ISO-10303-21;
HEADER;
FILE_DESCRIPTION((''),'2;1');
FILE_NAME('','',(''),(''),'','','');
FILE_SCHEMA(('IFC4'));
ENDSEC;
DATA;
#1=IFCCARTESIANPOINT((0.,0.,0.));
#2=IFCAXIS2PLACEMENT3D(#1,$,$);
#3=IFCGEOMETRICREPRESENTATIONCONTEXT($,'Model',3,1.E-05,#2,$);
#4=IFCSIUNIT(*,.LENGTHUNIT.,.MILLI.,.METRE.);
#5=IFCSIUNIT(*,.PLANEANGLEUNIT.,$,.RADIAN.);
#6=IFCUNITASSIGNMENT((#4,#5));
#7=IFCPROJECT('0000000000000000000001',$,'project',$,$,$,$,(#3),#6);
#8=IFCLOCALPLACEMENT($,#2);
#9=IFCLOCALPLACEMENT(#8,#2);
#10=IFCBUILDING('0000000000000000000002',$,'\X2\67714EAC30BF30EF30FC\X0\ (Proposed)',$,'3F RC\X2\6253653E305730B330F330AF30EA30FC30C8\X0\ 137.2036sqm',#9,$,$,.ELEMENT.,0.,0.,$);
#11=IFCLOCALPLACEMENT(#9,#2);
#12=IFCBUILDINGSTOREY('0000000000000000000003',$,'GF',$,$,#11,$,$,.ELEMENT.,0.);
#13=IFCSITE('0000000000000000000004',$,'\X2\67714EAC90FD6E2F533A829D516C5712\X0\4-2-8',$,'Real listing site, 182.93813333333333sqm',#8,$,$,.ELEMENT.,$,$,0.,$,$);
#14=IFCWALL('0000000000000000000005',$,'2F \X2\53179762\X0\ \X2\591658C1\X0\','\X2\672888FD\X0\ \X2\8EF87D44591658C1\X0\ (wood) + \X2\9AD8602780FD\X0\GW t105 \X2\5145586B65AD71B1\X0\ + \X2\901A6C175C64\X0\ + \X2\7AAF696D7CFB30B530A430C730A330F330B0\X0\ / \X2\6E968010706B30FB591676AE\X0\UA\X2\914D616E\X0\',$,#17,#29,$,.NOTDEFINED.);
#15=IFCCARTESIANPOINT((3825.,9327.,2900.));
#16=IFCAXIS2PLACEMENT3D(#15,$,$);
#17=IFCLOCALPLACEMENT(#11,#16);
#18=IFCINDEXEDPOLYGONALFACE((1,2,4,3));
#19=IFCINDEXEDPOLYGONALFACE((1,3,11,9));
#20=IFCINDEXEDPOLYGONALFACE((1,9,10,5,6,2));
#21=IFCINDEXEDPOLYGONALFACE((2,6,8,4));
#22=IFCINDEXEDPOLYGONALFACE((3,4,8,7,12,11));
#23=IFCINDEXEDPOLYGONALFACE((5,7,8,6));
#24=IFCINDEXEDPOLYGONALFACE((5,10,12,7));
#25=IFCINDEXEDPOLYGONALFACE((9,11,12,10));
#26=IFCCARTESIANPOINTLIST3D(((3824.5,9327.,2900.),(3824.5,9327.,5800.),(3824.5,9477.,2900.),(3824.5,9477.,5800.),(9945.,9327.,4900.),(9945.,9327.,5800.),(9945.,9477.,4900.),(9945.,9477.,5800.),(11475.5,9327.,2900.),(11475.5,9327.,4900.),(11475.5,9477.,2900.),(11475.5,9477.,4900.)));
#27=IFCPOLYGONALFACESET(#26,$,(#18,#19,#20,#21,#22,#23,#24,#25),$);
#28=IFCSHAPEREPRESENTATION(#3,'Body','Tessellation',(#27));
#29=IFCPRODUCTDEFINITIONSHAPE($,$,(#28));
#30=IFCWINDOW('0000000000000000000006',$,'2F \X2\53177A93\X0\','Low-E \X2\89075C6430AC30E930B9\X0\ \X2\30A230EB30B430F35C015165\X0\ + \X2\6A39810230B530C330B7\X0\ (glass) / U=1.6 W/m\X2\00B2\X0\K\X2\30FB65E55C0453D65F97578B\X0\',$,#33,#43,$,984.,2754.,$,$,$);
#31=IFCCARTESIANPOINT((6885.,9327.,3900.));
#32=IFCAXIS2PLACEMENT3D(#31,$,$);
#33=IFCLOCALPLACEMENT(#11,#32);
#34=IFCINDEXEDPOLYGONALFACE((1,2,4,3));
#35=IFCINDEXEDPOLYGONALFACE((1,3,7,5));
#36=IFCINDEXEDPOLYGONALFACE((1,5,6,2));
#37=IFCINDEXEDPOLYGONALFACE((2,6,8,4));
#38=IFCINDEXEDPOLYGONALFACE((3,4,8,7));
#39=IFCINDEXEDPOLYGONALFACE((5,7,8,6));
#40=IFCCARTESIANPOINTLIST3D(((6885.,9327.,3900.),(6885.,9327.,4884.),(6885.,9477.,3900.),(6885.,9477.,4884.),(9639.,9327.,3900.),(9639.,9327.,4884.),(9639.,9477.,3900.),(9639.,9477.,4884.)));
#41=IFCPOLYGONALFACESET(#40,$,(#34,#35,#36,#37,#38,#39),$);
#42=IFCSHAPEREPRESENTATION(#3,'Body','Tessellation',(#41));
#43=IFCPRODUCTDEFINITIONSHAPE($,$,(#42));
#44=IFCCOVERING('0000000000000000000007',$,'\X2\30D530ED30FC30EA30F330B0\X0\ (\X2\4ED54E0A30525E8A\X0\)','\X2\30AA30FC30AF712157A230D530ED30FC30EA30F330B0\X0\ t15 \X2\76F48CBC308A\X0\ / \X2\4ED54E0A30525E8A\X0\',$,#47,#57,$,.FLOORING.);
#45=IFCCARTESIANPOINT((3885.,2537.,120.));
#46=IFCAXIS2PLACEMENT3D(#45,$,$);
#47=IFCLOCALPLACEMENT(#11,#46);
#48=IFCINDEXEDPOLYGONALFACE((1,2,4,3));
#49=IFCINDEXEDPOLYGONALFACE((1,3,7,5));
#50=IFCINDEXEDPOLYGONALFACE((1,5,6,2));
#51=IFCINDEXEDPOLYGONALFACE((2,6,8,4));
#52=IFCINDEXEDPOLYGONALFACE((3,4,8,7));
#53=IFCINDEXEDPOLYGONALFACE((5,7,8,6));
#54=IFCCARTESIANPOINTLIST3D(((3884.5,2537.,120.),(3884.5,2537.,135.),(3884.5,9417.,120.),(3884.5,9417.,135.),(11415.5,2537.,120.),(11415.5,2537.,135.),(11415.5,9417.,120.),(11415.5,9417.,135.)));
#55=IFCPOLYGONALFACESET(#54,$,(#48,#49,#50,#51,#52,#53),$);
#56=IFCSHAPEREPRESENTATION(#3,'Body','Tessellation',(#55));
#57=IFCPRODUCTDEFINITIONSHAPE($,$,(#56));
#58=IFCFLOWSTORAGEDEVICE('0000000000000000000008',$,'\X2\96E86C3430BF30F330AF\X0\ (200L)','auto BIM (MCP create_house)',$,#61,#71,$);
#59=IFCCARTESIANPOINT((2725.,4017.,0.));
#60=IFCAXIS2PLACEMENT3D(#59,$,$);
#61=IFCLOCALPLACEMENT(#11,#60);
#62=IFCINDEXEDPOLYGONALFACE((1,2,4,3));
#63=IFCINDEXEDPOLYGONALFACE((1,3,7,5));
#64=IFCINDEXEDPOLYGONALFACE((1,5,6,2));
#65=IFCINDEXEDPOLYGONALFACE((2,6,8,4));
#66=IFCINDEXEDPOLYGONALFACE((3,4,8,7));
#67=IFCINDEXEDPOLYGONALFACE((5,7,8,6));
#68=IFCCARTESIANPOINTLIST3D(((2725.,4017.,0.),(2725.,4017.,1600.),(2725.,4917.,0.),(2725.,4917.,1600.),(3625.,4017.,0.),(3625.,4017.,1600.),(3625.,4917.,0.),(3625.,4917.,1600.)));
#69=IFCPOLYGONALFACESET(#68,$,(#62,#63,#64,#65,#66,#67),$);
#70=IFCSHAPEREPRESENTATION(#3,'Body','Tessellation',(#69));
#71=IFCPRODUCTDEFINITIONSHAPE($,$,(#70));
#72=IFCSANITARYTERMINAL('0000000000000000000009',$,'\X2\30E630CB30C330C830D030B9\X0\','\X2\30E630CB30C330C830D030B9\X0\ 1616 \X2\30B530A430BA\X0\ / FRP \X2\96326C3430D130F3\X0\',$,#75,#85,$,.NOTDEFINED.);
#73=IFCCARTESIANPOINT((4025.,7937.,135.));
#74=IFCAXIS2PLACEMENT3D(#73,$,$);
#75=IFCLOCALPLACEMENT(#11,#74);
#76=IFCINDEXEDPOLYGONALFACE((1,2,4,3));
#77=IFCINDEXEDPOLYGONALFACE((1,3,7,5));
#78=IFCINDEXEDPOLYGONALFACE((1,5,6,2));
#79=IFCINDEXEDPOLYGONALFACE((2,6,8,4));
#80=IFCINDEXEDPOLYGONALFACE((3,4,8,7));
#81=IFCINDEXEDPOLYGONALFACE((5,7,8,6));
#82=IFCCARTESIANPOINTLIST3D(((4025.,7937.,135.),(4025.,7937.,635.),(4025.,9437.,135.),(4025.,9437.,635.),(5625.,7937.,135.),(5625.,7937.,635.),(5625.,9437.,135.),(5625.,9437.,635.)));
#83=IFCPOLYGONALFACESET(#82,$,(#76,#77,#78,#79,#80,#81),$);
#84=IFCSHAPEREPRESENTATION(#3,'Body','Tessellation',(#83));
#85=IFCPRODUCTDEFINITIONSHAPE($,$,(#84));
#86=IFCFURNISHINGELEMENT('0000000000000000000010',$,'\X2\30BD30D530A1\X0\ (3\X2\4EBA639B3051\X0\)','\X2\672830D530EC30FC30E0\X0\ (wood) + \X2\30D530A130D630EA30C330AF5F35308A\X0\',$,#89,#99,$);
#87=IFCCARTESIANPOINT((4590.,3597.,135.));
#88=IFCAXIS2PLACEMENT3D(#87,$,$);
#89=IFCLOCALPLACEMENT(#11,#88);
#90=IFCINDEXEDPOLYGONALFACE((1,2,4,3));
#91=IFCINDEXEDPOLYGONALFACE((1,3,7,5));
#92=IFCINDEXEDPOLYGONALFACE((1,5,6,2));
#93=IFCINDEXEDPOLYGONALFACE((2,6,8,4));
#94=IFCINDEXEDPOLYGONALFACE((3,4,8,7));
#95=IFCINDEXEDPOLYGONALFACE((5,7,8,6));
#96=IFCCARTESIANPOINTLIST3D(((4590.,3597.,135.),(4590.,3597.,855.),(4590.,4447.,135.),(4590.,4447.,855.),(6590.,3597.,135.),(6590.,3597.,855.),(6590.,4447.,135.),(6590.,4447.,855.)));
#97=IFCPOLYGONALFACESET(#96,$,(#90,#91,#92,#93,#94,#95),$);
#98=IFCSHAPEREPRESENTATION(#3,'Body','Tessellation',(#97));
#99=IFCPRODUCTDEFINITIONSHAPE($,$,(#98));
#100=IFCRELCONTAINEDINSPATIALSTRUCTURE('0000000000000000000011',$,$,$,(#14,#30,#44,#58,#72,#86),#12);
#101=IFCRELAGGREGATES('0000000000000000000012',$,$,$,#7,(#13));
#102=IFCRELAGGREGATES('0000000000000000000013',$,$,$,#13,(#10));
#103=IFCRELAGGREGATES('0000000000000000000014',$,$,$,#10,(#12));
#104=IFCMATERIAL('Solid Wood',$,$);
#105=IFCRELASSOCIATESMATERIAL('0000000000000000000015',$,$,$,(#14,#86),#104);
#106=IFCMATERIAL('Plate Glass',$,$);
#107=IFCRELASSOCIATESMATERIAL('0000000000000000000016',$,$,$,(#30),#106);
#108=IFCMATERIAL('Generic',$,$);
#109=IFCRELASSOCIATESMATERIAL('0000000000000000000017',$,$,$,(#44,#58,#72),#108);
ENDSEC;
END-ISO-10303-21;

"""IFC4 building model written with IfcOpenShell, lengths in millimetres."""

from ifc_helpers import new_model, si_unit, frame, frame_2d, origin, place, context, project, spatial, rectangle, extrude, material, element, fill, save


model = new_model("IFC4")

# Units and contexts
model_context = context("Model", 3, precision=1e-05, world=origin())
ifc_project = project(units=[si_unit("LENGTHUNIT", "METRE", prefix="MILLI"), si_unit("PLANEANGLEUNIT", "RADIAN")], contexts=[model_context])

# Site, building, storey
site_placement = place(None, origin())
site = spatial("IfcSite", under=ifc_project, at=site_placement, Name="東京都港区芝公園4-2-8", ObjectType="Real listing site, 182.93813333333333sqm", CompositionType="ELEMENT", RefElevation=0.0)
building_placement = place(site_placement, origin())
building = spatial("IfcBuilding", under=site, at=building_placement, Name="東京タワー (Proposed)", ObjectType="3F RC打放しコンクリート 137.2036sqm", CompositionType="ELEMENT", ElevationOfRefHeight=0.0, ElevationOfTerrain=0.0)
storey_placement = place(building_placement, origin())
storey = spatial("IfcBuildingStorey", under=building, at=storey_placement, Name="GF", CompositionType="ELEMENT", Elevation=0.0)

# Shared definitions
ifc_material_1 = material(Name="Solid Wood")

# Shared definitions
ifc_material_2 = material(Name="Plate Glass")

# Wall, opening, window
wall_1_placement = place(storey_placement, frame((3825.0, 9327.0, 2900.0)))
wall_1 = element("IfcWall", 1, at=wall_1_placement, inside=storey, material=ifc_material_1, Name="2F 北面 外壁", Description="木製 軸組外壁 (wood) + 高性能GW t105 充填断熱 + 通気層 + 窯業系サイディング / 準耐火・外皮UA配慮", PredefinedType="NOTDEFINED", context=model_context, shape_type="SweptSolid", body=[
    extrude(rectangle(XDim=7651.0, YDim=150.0, at=frame_2d((3825.0, 75.0))), frame((3825.0, 9327.0, 2900.0)), (0.0, 0.0, 1.0), 2900.0),
])
opening_1_placement = place(storey_placement, frame((6885.0, 9327.0, 3900.0)))
opening_1 = element("IfcOpeningElement", 2, at=opening_1_placement, cuts=wall_1, PredefinedType="NOTDEFINED", context=model_context, shape_type="SweptSolid", body=[
    extrude(rectangle(XDim=2754.0, YDim=150.0, at=frame_2d((1377.0, 75.0))), frame((6885.0, 9327.0, 3900.0)), (0.0, 0.0, 1.0), 984.0),
])
window_1_placement = place(storey_placement, frame((6885.0, 9327.0, 3900.0)))
window_1 = element("IfcWindow", 3, at=window_1_placement, inside=storey, material=ifc_material_2, Name="2F 北窓", Description="Low-E 複層ガラス アルゴン封入 + 樹脂サッシ (glass) / U=1.6 W/m²K・日射取得型", OverallHeight=984.0, OverallWidth=2754.0, context=model_context, shape_type="SweptSolid", body=[
    extrude(rectangle(XDim=2754.0, YDim=150.0, at=frame_2d((1377.0, 75.0))), frame((6885.0, 9327.0, 3900.0)), (0.0, 0.0, 1.0), 984.0),
])
fill(opening_1, window_1)

# Covering
ifc_material_3 = material(Name="Generic")
covering_placement = place(storey_placement, frame((3885.0, 2537.0, 120.0)))
element("IfcCovering", 4, at=covering_placement, inside=storey, material=ifc_material_3, Name="フローリング (仕上げ床)", Description="オーク無垢フローリング t15 直貼り / 仕上げ床", PredefinedType="FLOORING", context=model_context, shape_type="SweptSolid", body=[
    extrude(rectangle(XDim=7531.0, YDim=6880.0, at=frame_2d((3765.0, 3440.0))), frame((3885.0, 2537.0, 120.0)), (0.0, 0.0, 1.0), 15.0),
])

# Flow storage device
flow_storage_device_placement = place(storey_placement, frame((2725.0, 4017.0, 0.0)))
element("IfcFlowStorageDevice", 5, at=flow_storage_device_placement, inside=storey, material=ifc_material_3, Name="雨水タンク (200L)", Description="auto BIM (MCP create_house)", context=model_context, shape_type="SweptSolid", body=[
    extrude(rectangle(XDim=900.0, YDim=900.0, at=frame_2d((450.0, 450.0))), frame((2725.0, 4017.0, 0.0)), (0.0, 0.0, 1.0), 1600.0),
])

# Sanitary terminal
sanitary_terminal_placement = place(storey_placement, frame((4025.0, 7937.0, 135.0)))
element("IfcSanitaryTerminal", 6, at=sanitary_terminal_placement, inside=storey, material=ifc_material_3, Name="ユニットバス", Description="ユニットバス 1616 サイズ / FRP 防水パン", PredefinedType="NOTDEFINED", context=model_context, shape_type="SweptSolid", body=[
    extrude(rectangle(XDim=1600.0, YDim=1500.0, at=frame_2d((800.0, 750.0))), frame((4025.0, 7937.0, 135.0)), (0.0, 0.0, 1.0), 500.0),
])

# Furnishing element
furnishing_placement = place(storey_placement, frame((4590.0, 3597.0, 135.0)))
element("IfcFurnishingElement", 7, at=furnishing_placement, inside=storey, material=ifc_material_1, Name="ソファ (3人掛け)", Description="木フレーム (wood) + ファブリック張り", context=model_context, shape_type="SweptSolid", body=[
    extrude(rectangle(XDim=2000.0, YDim=850.0, at=frame_2d((1000.0, 425.0))), frame((4590.0, 3597.0, 135.0)), (0.0, 0.0, 1.0), 720.0),
])

save(model, "model.ifc")
